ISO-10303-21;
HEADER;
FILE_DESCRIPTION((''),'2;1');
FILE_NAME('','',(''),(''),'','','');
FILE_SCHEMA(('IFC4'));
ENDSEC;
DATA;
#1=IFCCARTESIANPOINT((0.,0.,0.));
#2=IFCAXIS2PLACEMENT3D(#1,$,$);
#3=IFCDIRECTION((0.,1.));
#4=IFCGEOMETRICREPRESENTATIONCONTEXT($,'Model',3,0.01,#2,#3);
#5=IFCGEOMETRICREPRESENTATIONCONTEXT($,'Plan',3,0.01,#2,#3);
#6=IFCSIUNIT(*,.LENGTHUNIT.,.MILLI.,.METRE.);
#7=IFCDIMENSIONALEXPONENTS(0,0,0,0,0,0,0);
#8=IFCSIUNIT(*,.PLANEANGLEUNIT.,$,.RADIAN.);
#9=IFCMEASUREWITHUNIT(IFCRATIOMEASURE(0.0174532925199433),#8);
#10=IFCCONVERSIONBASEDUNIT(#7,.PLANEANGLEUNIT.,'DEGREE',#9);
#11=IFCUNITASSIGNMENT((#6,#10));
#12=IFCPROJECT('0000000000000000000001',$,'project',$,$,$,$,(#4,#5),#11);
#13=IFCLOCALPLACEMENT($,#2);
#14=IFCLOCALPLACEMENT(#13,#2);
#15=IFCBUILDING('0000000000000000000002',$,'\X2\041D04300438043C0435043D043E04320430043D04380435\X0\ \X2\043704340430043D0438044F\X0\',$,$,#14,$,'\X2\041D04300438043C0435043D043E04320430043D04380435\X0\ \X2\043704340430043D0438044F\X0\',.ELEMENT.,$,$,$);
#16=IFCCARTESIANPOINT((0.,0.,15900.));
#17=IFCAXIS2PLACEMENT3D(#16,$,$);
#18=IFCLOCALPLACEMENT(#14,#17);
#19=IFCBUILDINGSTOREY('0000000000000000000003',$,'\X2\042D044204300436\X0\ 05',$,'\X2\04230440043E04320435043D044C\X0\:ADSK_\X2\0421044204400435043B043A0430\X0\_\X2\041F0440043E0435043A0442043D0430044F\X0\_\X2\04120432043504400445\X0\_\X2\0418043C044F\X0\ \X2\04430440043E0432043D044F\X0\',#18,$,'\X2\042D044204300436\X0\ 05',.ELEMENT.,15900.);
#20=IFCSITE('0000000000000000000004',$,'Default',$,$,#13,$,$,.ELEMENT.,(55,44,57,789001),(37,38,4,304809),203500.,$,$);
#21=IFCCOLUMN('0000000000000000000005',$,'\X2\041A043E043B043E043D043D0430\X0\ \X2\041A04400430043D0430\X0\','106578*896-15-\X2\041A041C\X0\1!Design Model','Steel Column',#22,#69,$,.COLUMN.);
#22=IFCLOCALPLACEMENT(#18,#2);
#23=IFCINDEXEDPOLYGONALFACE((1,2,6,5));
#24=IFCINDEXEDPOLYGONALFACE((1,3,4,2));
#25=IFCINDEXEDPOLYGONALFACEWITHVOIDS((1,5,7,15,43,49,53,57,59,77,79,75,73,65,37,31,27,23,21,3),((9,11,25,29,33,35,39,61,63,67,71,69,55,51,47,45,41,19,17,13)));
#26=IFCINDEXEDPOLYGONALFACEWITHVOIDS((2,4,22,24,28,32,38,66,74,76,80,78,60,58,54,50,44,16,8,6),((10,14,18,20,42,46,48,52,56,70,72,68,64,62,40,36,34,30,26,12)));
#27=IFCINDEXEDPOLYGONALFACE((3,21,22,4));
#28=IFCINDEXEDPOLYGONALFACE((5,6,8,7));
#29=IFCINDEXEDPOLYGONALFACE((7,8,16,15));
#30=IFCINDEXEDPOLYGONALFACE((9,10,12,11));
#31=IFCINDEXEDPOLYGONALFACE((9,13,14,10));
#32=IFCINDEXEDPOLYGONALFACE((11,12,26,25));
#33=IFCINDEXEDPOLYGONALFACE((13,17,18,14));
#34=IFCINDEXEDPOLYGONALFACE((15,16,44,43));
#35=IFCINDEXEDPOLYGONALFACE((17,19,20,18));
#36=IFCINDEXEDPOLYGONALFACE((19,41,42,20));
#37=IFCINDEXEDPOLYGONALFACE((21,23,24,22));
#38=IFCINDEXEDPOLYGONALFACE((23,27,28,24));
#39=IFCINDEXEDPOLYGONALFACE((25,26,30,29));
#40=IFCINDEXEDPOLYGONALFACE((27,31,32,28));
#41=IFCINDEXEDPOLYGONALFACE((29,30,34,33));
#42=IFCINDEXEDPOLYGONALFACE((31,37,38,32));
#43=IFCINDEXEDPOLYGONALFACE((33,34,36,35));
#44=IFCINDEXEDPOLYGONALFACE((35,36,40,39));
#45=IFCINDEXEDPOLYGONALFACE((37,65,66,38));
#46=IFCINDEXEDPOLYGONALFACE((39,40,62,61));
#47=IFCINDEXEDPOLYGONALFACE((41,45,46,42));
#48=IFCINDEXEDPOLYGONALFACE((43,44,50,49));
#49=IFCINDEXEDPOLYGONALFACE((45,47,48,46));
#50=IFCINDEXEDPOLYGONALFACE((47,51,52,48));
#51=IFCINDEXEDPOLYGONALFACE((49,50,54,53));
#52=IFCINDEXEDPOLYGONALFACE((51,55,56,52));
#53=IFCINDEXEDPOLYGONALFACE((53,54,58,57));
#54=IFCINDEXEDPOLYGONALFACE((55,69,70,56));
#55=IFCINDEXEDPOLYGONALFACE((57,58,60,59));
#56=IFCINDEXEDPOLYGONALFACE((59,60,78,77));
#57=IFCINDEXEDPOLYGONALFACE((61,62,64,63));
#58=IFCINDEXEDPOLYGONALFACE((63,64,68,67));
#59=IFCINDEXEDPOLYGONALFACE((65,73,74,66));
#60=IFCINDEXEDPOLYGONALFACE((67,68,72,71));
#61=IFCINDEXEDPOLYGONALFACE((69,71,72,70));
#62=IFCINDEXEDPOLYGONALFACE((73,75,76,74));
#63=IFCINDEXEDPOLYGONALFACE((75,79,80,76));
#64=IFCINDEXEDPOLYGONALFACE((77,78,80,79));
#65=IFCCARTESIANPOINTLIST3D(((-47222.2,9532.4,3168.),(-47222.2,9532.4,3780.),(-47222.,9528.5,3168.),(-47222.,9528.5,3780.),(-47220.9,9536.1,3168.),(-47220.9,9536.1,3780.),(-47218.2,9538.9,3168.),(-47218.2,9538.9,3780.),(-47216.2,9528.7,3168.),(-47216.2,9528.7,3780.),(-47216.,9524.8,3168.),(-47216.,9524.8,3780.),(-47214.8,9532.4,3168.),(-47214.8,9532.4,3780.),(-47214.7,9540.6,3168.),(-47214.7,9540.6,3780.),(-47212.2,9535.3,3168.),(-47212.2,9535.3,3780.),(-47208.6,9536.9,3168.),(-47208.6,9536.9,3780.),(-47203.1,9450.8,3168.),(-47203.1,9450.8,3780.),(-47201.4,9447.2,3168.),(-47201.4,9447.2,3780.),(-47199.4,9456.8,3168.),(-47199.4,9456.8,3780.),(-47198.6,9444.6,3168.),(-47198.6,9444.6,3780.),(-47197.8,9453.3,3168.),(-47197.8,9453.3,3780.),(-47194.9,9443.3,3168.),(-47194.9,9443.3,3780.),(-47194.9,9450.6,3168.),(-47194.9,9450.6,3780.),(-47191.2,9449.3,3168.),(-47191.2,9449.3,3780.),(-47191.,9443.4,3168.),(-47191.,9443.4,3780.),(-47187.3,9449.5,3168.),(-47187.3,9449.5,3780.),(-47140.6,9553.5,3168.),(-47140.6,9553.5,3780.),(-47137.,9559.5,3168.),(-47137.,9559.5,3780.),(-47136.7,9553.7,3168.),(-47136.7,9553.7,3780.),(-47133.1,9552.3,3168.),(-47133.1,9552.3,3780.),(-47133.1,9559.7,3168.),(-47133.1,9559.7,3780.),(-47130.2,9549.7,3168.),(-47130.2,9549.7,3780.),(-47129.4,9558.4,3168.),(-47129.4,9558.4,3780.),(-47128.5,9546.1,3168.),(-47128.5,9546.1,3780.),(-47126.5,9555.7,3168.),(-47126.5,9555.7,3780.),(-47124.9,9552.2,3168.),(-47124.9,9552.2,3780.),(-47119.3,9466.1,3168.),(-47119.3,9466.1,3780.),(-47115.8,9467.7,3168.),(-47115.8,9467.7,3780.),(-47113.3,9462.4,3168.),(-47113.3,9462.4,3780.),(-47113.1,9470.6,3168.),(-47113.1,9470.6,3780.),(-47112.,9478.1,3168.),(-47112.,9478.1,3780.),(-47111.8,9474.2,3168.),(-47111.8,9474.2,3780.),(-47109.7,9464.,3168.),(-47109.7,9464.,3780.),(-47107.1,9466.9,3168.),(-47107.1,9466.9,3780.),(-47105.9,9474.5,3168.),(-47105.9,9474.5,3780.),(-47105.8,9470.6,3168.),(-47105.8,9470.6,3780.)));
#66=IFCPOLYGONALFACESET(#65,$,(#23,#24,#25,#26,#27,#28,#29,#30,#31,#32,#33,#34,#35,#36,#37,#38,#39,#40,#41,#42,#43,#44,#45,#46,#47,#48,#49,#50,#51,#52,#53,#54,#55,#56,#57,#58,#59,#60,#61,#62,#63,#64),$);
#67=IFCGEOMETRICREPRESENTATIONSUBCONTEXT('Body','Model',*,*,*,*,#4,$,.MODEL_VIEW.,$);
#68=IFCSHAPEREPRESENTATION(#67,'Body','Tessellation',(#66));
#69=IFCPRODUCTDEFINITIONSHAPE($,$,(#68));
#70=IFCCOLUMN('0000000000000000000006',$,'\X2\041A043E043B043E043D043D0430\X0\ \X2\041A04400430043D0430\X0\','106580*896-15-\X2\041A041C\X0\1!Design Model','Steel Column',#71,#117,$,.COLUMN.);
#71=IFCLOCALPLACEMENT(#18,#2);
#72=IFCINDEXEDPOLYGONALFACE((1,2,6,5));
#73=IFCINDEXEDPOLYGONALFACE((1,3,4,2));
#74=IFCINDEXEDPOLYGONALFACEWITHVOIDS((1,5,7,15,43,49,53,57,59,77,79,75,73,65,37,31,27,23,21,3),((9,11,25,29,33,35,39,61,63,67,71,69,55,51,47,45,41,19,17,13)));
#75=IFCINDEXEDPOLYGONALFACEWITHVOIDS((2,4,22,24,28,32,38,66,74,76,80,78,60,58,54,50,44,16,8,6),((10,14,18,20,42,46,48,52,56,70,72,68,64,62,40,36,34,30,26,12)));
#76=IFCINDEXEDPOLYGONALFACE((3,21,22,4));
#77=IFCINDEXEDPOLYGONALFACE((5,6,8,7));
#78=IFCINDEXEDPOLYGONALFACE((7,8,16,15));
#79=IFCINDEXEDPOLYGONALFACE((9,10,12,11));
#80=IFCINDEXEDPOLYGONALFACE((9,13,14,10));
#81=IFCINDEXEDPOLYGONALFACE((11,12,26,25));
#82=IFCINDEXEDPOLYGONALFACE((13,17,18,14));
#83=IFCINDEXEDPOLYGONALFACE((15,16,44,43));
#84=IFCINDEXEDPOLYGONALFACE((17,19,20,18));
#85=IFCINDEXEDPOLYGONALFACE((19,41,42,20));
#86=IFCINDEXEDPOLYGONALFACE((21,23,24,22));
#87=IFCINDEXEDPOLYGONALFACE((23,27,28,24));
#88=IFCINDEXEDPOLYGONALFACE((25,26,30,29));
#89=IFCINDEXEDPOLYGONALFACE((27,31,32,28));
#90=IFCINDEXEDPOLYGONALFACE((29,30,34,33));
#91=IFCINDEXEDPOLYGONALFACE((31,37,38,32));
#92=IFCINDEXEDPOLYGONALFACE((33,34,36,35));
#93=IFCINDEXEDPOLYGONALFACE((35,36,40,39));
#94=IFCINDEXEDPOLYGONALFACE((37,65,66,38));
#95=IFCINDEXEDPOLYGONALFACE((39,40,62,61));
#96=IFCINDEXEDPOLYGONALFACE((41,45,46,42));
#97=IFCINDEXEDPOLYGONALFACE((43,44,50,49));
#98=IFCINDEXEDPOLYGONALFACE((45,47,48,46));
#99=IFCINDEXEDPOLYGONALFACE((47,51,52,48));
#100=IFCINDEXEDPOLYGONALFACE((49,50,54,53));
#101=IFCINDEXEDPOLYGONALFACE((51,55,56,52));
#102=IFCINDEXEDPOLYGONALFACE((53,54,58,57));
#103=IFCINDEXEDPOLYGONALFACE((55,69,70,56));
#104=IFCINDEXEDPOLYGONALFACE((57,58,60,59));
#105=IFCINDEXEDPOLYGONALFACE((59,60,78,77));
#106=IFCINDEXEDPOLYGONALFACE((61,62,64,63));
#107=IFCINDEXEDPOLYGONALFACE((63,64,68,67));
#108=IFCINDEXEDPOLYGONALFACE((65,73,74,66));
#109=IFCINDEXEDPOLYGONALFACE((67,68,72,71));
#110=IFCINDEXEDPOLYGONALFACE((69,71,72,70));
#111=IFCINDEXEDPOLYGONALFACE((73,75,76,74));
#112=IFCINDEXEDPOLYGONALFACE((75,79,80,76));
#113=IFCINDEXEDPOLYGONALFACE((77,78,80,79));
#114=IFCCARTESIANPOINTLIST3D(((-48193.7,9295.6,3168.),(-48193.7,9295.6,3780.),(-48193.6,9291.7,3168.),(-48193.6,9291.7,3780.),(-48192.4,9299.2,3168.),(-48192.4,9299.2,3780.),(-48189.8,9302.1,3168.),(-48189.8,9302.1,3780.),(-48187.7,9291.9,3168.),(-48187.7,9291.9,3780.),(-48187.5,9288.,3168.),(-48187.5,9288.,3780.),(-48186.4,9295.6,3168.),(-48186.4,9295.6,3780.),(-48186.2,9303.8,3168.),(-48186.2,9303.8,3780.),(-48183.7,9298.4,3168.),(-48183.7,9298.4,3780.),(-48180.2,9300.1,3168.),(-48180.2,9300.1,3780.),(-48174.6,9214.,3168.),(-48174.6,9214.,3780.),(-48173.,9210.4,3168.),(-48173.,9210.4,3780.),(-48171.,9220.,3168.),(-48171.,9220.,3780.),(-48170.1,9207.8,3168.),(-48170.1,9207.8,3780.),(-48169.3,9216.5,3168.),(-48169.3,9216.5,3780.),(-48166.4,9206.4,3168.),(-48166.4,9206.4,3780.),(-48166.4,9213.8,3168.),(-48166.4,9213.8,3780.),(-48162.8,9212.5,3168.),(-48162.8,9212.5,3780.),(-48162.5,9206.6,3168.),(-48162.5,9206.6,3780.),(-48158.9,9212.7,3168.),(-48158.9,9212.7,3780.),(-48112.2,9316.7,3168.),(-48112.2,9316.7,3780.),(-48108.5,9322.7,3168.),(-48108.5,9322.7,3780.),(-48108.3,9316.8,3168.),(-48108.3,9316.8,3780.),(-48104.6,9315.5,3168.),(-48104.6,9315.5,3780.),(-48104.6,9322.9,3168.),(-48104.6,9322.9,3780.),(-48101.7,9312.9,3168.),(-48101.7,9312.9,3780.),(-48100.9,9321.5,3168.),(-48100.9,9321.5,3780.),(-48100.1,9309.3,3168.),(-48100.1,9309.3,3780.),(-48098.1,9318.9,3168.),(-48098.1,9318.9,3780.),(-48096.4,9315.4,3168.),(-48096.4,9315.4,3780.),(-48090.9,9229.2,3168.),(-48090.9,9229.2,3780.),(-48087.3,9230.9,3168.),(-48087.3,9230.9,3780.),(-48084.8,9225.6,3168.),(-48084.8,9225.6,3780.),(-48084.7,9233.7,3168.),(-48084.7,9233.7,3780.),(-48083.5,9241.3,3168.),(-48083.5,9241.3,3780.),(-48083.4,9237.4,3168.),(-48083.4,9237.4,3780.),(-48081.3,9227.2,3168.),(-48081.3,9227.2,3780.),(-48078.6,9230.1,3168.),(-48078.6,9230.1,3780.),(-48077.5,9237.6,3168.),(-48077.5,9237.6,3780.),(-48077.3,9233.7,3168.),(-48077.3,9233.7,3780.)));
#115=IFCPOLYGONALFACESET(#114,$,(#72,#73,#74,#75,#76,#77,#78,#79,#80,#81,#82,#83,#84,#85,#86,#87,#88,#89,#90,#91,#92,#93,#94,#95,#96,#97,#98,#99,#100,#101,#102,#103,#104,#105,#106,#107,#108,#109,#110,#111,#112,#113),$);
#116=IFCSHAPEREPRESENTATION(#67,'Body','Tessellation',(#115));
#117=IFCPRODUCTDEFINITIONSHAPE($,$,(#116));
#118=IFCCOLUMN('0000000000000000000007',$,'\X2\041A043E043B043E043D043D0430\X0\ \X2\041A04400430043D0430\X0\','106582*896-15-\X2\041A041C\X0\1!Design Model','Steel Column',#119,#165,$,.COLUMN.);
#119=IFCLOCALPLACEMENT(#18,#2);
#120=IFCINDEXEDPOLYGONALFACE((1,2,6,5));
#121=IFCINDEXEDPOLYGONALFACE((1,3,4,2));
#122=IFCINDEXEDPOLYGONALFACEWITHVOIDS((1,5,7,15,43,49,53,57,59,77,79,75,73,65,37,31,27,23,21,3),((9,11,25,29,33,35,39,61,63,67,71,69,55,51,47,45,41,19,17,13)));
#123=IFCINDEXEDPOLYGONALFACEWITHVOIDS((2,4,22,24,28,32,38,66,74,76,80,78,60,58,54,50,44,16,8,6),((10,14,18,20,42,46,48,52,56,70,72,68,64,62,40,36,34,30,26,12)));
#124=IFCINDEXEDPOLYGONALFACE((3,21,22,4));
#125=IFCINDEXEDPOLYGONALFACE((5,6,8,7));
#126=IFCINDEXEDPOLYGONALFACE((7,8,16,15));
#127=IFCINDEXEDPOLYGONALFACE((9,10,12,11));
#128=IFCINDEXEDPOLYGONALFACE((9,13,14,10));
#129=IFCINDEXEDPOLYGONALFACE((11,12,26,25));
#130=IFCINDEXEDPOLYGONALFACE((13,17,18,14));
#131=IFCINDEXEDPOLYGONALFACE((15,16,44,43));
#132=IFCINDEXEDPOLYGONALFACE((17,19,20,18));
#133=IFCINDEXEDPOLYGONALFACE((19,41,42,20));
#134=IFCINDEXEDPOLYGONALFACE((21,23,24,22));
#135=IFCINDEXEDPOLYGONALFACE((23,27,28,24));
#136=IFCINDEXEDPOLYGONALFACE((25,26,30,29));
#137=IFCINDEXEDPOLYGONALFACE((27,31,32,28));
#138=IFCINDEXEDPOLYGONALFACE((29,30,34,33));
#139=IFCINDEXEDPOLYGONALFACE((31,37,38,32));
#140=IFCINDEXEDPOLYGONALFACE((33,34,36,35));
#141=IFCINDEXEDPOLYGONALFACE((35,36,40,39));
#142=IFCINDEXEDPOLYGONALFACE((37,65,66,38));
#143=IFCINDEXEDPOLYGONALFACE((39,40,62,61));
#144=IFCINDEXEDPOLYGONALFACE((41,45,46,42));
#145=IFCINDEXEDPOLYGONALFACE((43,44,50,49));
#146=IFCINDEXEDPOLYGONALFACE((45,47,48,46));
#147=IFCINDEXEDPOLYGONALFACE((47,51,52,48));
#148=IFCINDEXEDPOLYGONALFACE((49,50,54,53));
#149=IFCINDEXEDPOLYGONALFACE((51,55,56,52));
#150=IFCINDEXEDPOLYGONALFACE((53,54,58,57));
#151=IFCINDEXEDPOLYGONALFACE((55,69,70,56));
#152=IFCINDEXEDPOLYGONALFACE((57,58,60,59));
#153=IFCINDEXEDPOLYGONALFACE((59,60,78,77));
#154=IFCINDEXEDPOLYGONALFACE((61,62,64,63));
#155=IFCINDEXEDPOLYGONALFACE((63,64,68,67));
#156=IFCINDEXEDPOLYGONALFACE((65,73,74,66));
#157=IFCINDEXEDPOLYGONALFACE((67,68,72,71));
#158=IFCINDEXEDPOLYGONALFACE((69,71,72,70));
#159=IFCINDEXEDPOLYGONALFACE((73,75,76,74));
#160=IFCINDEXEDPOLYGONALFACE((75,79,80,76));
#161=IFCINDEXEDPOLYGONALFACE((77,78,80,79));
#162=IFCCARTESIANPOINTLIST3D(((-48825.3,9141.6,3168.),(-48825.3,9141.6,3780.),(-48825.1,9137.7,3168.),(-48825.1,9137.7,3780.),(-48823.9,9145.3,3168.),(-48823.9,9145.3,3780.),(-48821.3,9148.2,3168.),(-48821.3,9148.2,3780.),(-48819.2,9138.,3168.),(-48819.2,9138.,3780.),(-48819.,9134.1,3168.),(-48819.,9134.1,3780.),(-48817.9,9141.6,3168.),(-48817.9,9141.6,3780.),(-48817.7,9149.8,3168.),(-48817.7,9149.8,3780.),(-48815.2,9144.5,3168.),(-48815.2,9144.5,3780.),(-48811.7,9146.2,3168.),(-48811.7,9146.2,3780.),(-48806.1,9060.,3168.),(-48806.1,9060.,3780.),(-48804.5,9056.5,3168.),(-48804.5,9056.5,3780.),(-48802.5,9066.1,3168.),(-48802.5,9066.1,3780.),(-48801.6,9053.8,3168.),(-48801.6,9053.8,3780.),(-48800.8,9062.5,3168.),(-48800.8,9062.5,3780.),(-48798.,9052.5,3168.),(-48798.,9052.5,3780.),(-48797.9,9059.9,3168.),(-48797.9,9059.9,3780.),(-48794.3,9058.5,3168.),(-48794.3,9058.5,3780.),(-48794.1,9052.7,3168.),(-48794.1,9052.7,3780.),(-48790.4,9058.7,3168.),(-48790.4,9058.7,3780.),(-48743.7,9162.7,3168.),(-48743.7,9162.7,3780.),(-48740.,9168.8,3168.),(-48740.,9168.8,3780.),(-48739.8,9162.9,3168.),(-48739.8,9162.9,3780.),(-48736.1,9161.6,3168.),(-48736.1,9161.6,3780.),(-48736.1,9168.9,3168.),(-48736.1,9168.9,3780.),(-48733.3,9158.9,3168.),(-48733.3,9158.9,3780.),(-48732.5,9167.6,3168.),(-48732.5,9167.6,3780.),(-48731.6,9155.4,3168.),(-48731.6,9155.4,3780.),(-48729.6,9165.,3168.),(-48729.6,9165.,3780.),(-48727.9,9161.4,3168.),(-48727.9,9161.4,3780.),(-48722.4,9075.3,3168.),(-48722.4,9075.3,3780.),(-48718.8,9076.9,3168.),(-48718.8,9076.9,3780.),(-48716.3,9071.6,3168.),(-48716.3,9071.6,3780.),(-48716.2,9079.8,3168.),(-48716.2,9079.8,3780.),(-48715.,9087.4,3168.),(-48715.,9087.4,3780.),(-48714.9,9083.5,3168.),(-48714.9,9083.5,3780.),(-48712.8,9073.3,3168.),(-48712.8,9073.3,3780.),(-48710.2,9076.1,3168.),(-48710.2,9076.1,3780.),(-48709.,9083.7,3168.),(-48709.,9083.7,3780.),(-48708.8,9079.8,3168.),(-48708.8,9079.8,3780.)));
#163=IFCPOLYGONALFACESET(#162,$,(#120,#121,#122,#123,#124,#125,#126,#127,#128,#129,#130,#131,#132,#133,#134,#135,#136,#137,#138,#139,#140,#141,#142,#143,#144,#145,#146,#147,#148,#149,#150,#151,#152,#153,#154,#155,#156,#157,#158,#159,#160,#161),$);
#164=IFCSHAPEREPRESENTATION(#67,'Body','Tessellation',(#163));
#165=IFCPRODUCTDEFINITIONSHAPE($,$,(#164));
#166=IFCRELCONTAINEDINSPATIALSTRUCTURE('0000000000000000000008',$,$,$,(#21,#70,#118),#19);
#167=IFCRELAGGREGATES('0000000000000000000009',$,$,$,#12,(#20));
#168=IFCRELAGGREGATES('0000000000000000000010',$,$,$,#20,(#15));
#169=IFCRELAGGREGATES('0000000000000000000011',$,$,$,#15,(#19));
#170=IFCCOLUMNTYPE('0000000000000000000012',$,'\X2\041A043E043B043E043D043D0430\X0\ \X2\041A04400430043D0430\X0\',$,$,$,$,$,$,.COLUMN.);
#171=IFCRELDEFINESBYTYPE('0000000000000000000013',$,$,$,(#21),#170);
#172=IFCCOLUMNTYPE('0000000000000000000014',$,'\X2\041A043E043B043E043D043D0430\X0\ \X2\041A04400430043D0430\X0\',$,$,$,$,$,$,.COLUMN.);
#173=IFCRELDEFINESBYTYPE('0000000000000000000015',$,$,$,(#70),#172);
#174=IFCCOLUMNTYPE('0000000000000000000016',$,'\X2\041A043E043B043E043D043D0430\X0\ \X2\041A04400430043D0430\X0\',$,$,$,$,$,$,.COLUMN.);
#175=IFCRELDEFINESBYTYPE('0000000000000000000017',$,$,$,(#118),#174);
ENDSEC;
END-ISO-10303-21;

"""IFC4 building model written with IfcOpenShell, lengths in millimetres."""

from ifc_helpers import new_model, entity, si_unit, converted_unit, direction, frame, origin, place, context, subcontext, project, spatial, indexed_curve, outline, extrude, type_object, element, save


model = new_model("IFC4")

# Units and contexts
model_context = context("Model", 3, precision=0.01, world=origin(), true_north=direction((0.0, 1.0)))
plan_context = context("Plan", 3, precision=0.01, world=origin(), true_north=direction((0.0, 1.0)))
body_context = subcontext(model_context, "Body", "Model", "MODEL_VIEW")
ifc_project = project(units=[si_unit("LENGTHUNIT", "METRE", prefix="MILLI"), converted_unit("PLANEANGLEUNIT", "DEGREE", entity("IfcRatioMeasure", 0.0174532925199433), si_unit("PLANEANGLEUNIT", "RADIAN"), dimensions=[0, 0, 0, 0, 0, 0, 0])], contexts=[model_context, plan_context])

# Site, building, storey
site_placement = place(None, origin())
site = spatial("IfcSite", under=ifc_project, at=site_placement, Name="Default", CompositionType="ELEMENT", RefLatitude=(55, 44, 57, 789001), RefLongitude=(37, 38, 4, 304809), RefElevation=203500.0)
building_placement = place(site_placement, origin())
building = spatial("IfcBuilding", under=site, at=building_placement, Name="Наименование здания", LongName="Наименование здания", CompositionType="ELEMENT")
storey_placement = place(building_placement, frame((0.0, 0.0, 15900.0)))
storey = spatial("IfcBuildingStorey", under=building, at=storey_placement, Name="Этаж 05", ObjectType="Уровень:ADSK_Стрелка_Проектная_Вверх_Имя уровня", LongName="Этаж 05", CompositionType="ELEMENT", Elevation=15900.0)

# Columns
column_type_1 = type_object("IfcColumnType", Name="Колонна Крана", PredefinedType="COLUMN")
column_1_placement = place(storey_placement, origin())
element("IfcColumn", 1, at=column_1_placement, inside=storey, type_object=column_type_1, Name="Колонна Крана", Description="106578*896-15-КМ1!Design Model", ObjectType="Steel Column", PredefinedType="COLUMN", context=body_context, shape_type="SweptSolid", body=[
    extrude(outline(indexed_curve([(29.5, -56.8), (33.4, -56.8), (37.0, -55.3), (39.7, -52.6), (41.2, -49.0), (56.8, 29.5), (56.8, 33.4), (55.3, 37.0), (52.6, 39.7), (49.0, 41.2), (-29.5, 56.8), (-33.4, 56.8), (-37.0, 55.3), (-39.7, 52.6), (-41.2, 49.0), (-56.8, -29.5), (-56.8, -33.4), (-55.3, -37.0), (-52.6, -39.7), (-49.0, -41.2), (29.5, -56.8)], self_intersect=False), holes=[indexed_curve([(-43.1, -37.3), (-46.7, -35.8), (-49.5, -33.1), (-51.0, -29.5), (-51.0, -25.5), (-37.3, 43.1), (-35.8, 46.7), (-33.1, 49.5), (-29.5, 51.0), (-25.5, 51.0), (43.1, 37.3), (46.7, 35.8), (49.5, 33.1), (51.0, 29.5), (51.0, 25.5), (37.3, -43.1), (35.8, -46.7), (33.1, -49.5), (29.5, -51.0), (25.5, -51.0), (-43.1, -37.3)], self_intersect=False)]), frame((-47164.0, 9501.5, 3168.0), z_axis=(0.0, 0.0, 1.0), x_axis=(0.906681, 0.421816, 0.0)), (0.0, 0.0, 1.0), 612.0),
])
column_type_2 = type_object("IfcColumnType", Name="Колонна Крана", PredefinedType="COLUMN")
column_2_placement = place(storey_placement, origin())
element("IfcColumn", 2, at=column_2_placement, inside=storey, type_object=column_type_2, Name="Колонна Крана", Description="106580*896-15-КМ1!Design Model", ObjectType="Steel Column", PredefinedType="COLUMN", context=body_context, shape_type="SweptSolid", body=[
    extrude(outline(indexed_curve([(29.5, -56.8), (33.4, -56.8), (37.0, -55.3), (39.7, -52.6), (41.2, -49.0), (56.8, 29.5), (56.8, 33.4), (55.3, 37.0), (52.6, 39.7), (49.0, 41.2), (-29.5, 56.8), (-33.4, 56.8), (-37.0, 55.3), (-39.7, 52.6), (-41.2, 49.0), (-56.8, -29.5), (-56.8, -33.4), (-55.3, -37.0), (-52.6, -39.7), (-49.0, -41.2), (29.5, -56.8)], self_intersect=False), holes=[indexed_curve([(-43.1, -37.3), (-46.7, -35.8), (-49.5, -33.1), (-51.0, -29.5), (-51.0, -25.5), (-37.3, 43.1), (-35.8, 46.7), (-33.1, 49.5), (-29.5, 51.0), (-25.5, 51.0), (43.1, 37.3), (46.7, 35.8), (49.5, 33.1), (51.0, 29.5), (51.0, 25.5), (37.3, -43.1), (35.8, -46.7), (33.1, -49.5), (29.5, -51.0), (25.5, -51.0), (-43.1, -37.3)], self_intersect=False)]), frame((-48135.5, 9264.7, 3168.0), z_axis=(0.0, 0.0, 1.0), x_axis=(0.906681, 0.421816, 0.0)), (0.0, 0.0, 1.0), 612.0),
])
column_type_3 = type_object("IfcColumnType", Name="Колонна Крана", PredefinedType="COLUMN")
column_3_placement = place(storey_placement, origin())
element("IfcColumn", 3, at=column_3_placement, inside=storey, type_object=column_type_3, Name="Колонна Крана", Description="106582*896-15-КМ1!Design Model", ObjectType="Steel Column", PredefinedType="COLUMN", context=body_context, shape_type="SweptSolid", body=[
    extrude(outline(indexed_curve([(29.5, -56.8), (33.4, -56.8), (37.0, -55.3), (39.7, -52.6), (41.2, -49.0), (56.8, 29.5), (56.8, 33.4), (55.3, 37.0), (52.6, 39.7), (49.0, 41.2), (-29.5, 56.8), (-33.4, 56.8), (-37.0, 55.3), (-39.7, 52.6), (-41.2, 49.0), (-56.8, -29.5), (-56.8, -33.4), (-55.3, -37.0), (-52.6, -39.7), (-49.0, -41.2), (29.5, -56.8)], self_intersect=False), holes=[indexed_curve([(-43.1, -37.3), (-46.7, -35.8), (-49.5, -33.1), (-51.0, -29.5), (-51.0, -25.5), (-37.3, 43.1), (-35.8, 46.7), (-33.1, 49.5), (-29.5, 51.0), (-25.5, 51.0), (43.1, 37.3), (46.7, 35.8), (49.5, 33.1), (51.0, 29.5), (51.0, 25.5), (37.3, -43.1), (35.8, -46.7), (33.1, -49.5), (29.5, -51.0), (25.5, -51.0), (-43.1, -37.3)], self_intersect=False)]), frame((-48767.0, 9110.7, 3168.0), z_axis=(0.0, 0.0, 1.0), x_axis=(0.906681, 0.421816, 0.0)), (0.0, 0.0, 1.0), 612.0),
])

save(model, "model.ifc")
